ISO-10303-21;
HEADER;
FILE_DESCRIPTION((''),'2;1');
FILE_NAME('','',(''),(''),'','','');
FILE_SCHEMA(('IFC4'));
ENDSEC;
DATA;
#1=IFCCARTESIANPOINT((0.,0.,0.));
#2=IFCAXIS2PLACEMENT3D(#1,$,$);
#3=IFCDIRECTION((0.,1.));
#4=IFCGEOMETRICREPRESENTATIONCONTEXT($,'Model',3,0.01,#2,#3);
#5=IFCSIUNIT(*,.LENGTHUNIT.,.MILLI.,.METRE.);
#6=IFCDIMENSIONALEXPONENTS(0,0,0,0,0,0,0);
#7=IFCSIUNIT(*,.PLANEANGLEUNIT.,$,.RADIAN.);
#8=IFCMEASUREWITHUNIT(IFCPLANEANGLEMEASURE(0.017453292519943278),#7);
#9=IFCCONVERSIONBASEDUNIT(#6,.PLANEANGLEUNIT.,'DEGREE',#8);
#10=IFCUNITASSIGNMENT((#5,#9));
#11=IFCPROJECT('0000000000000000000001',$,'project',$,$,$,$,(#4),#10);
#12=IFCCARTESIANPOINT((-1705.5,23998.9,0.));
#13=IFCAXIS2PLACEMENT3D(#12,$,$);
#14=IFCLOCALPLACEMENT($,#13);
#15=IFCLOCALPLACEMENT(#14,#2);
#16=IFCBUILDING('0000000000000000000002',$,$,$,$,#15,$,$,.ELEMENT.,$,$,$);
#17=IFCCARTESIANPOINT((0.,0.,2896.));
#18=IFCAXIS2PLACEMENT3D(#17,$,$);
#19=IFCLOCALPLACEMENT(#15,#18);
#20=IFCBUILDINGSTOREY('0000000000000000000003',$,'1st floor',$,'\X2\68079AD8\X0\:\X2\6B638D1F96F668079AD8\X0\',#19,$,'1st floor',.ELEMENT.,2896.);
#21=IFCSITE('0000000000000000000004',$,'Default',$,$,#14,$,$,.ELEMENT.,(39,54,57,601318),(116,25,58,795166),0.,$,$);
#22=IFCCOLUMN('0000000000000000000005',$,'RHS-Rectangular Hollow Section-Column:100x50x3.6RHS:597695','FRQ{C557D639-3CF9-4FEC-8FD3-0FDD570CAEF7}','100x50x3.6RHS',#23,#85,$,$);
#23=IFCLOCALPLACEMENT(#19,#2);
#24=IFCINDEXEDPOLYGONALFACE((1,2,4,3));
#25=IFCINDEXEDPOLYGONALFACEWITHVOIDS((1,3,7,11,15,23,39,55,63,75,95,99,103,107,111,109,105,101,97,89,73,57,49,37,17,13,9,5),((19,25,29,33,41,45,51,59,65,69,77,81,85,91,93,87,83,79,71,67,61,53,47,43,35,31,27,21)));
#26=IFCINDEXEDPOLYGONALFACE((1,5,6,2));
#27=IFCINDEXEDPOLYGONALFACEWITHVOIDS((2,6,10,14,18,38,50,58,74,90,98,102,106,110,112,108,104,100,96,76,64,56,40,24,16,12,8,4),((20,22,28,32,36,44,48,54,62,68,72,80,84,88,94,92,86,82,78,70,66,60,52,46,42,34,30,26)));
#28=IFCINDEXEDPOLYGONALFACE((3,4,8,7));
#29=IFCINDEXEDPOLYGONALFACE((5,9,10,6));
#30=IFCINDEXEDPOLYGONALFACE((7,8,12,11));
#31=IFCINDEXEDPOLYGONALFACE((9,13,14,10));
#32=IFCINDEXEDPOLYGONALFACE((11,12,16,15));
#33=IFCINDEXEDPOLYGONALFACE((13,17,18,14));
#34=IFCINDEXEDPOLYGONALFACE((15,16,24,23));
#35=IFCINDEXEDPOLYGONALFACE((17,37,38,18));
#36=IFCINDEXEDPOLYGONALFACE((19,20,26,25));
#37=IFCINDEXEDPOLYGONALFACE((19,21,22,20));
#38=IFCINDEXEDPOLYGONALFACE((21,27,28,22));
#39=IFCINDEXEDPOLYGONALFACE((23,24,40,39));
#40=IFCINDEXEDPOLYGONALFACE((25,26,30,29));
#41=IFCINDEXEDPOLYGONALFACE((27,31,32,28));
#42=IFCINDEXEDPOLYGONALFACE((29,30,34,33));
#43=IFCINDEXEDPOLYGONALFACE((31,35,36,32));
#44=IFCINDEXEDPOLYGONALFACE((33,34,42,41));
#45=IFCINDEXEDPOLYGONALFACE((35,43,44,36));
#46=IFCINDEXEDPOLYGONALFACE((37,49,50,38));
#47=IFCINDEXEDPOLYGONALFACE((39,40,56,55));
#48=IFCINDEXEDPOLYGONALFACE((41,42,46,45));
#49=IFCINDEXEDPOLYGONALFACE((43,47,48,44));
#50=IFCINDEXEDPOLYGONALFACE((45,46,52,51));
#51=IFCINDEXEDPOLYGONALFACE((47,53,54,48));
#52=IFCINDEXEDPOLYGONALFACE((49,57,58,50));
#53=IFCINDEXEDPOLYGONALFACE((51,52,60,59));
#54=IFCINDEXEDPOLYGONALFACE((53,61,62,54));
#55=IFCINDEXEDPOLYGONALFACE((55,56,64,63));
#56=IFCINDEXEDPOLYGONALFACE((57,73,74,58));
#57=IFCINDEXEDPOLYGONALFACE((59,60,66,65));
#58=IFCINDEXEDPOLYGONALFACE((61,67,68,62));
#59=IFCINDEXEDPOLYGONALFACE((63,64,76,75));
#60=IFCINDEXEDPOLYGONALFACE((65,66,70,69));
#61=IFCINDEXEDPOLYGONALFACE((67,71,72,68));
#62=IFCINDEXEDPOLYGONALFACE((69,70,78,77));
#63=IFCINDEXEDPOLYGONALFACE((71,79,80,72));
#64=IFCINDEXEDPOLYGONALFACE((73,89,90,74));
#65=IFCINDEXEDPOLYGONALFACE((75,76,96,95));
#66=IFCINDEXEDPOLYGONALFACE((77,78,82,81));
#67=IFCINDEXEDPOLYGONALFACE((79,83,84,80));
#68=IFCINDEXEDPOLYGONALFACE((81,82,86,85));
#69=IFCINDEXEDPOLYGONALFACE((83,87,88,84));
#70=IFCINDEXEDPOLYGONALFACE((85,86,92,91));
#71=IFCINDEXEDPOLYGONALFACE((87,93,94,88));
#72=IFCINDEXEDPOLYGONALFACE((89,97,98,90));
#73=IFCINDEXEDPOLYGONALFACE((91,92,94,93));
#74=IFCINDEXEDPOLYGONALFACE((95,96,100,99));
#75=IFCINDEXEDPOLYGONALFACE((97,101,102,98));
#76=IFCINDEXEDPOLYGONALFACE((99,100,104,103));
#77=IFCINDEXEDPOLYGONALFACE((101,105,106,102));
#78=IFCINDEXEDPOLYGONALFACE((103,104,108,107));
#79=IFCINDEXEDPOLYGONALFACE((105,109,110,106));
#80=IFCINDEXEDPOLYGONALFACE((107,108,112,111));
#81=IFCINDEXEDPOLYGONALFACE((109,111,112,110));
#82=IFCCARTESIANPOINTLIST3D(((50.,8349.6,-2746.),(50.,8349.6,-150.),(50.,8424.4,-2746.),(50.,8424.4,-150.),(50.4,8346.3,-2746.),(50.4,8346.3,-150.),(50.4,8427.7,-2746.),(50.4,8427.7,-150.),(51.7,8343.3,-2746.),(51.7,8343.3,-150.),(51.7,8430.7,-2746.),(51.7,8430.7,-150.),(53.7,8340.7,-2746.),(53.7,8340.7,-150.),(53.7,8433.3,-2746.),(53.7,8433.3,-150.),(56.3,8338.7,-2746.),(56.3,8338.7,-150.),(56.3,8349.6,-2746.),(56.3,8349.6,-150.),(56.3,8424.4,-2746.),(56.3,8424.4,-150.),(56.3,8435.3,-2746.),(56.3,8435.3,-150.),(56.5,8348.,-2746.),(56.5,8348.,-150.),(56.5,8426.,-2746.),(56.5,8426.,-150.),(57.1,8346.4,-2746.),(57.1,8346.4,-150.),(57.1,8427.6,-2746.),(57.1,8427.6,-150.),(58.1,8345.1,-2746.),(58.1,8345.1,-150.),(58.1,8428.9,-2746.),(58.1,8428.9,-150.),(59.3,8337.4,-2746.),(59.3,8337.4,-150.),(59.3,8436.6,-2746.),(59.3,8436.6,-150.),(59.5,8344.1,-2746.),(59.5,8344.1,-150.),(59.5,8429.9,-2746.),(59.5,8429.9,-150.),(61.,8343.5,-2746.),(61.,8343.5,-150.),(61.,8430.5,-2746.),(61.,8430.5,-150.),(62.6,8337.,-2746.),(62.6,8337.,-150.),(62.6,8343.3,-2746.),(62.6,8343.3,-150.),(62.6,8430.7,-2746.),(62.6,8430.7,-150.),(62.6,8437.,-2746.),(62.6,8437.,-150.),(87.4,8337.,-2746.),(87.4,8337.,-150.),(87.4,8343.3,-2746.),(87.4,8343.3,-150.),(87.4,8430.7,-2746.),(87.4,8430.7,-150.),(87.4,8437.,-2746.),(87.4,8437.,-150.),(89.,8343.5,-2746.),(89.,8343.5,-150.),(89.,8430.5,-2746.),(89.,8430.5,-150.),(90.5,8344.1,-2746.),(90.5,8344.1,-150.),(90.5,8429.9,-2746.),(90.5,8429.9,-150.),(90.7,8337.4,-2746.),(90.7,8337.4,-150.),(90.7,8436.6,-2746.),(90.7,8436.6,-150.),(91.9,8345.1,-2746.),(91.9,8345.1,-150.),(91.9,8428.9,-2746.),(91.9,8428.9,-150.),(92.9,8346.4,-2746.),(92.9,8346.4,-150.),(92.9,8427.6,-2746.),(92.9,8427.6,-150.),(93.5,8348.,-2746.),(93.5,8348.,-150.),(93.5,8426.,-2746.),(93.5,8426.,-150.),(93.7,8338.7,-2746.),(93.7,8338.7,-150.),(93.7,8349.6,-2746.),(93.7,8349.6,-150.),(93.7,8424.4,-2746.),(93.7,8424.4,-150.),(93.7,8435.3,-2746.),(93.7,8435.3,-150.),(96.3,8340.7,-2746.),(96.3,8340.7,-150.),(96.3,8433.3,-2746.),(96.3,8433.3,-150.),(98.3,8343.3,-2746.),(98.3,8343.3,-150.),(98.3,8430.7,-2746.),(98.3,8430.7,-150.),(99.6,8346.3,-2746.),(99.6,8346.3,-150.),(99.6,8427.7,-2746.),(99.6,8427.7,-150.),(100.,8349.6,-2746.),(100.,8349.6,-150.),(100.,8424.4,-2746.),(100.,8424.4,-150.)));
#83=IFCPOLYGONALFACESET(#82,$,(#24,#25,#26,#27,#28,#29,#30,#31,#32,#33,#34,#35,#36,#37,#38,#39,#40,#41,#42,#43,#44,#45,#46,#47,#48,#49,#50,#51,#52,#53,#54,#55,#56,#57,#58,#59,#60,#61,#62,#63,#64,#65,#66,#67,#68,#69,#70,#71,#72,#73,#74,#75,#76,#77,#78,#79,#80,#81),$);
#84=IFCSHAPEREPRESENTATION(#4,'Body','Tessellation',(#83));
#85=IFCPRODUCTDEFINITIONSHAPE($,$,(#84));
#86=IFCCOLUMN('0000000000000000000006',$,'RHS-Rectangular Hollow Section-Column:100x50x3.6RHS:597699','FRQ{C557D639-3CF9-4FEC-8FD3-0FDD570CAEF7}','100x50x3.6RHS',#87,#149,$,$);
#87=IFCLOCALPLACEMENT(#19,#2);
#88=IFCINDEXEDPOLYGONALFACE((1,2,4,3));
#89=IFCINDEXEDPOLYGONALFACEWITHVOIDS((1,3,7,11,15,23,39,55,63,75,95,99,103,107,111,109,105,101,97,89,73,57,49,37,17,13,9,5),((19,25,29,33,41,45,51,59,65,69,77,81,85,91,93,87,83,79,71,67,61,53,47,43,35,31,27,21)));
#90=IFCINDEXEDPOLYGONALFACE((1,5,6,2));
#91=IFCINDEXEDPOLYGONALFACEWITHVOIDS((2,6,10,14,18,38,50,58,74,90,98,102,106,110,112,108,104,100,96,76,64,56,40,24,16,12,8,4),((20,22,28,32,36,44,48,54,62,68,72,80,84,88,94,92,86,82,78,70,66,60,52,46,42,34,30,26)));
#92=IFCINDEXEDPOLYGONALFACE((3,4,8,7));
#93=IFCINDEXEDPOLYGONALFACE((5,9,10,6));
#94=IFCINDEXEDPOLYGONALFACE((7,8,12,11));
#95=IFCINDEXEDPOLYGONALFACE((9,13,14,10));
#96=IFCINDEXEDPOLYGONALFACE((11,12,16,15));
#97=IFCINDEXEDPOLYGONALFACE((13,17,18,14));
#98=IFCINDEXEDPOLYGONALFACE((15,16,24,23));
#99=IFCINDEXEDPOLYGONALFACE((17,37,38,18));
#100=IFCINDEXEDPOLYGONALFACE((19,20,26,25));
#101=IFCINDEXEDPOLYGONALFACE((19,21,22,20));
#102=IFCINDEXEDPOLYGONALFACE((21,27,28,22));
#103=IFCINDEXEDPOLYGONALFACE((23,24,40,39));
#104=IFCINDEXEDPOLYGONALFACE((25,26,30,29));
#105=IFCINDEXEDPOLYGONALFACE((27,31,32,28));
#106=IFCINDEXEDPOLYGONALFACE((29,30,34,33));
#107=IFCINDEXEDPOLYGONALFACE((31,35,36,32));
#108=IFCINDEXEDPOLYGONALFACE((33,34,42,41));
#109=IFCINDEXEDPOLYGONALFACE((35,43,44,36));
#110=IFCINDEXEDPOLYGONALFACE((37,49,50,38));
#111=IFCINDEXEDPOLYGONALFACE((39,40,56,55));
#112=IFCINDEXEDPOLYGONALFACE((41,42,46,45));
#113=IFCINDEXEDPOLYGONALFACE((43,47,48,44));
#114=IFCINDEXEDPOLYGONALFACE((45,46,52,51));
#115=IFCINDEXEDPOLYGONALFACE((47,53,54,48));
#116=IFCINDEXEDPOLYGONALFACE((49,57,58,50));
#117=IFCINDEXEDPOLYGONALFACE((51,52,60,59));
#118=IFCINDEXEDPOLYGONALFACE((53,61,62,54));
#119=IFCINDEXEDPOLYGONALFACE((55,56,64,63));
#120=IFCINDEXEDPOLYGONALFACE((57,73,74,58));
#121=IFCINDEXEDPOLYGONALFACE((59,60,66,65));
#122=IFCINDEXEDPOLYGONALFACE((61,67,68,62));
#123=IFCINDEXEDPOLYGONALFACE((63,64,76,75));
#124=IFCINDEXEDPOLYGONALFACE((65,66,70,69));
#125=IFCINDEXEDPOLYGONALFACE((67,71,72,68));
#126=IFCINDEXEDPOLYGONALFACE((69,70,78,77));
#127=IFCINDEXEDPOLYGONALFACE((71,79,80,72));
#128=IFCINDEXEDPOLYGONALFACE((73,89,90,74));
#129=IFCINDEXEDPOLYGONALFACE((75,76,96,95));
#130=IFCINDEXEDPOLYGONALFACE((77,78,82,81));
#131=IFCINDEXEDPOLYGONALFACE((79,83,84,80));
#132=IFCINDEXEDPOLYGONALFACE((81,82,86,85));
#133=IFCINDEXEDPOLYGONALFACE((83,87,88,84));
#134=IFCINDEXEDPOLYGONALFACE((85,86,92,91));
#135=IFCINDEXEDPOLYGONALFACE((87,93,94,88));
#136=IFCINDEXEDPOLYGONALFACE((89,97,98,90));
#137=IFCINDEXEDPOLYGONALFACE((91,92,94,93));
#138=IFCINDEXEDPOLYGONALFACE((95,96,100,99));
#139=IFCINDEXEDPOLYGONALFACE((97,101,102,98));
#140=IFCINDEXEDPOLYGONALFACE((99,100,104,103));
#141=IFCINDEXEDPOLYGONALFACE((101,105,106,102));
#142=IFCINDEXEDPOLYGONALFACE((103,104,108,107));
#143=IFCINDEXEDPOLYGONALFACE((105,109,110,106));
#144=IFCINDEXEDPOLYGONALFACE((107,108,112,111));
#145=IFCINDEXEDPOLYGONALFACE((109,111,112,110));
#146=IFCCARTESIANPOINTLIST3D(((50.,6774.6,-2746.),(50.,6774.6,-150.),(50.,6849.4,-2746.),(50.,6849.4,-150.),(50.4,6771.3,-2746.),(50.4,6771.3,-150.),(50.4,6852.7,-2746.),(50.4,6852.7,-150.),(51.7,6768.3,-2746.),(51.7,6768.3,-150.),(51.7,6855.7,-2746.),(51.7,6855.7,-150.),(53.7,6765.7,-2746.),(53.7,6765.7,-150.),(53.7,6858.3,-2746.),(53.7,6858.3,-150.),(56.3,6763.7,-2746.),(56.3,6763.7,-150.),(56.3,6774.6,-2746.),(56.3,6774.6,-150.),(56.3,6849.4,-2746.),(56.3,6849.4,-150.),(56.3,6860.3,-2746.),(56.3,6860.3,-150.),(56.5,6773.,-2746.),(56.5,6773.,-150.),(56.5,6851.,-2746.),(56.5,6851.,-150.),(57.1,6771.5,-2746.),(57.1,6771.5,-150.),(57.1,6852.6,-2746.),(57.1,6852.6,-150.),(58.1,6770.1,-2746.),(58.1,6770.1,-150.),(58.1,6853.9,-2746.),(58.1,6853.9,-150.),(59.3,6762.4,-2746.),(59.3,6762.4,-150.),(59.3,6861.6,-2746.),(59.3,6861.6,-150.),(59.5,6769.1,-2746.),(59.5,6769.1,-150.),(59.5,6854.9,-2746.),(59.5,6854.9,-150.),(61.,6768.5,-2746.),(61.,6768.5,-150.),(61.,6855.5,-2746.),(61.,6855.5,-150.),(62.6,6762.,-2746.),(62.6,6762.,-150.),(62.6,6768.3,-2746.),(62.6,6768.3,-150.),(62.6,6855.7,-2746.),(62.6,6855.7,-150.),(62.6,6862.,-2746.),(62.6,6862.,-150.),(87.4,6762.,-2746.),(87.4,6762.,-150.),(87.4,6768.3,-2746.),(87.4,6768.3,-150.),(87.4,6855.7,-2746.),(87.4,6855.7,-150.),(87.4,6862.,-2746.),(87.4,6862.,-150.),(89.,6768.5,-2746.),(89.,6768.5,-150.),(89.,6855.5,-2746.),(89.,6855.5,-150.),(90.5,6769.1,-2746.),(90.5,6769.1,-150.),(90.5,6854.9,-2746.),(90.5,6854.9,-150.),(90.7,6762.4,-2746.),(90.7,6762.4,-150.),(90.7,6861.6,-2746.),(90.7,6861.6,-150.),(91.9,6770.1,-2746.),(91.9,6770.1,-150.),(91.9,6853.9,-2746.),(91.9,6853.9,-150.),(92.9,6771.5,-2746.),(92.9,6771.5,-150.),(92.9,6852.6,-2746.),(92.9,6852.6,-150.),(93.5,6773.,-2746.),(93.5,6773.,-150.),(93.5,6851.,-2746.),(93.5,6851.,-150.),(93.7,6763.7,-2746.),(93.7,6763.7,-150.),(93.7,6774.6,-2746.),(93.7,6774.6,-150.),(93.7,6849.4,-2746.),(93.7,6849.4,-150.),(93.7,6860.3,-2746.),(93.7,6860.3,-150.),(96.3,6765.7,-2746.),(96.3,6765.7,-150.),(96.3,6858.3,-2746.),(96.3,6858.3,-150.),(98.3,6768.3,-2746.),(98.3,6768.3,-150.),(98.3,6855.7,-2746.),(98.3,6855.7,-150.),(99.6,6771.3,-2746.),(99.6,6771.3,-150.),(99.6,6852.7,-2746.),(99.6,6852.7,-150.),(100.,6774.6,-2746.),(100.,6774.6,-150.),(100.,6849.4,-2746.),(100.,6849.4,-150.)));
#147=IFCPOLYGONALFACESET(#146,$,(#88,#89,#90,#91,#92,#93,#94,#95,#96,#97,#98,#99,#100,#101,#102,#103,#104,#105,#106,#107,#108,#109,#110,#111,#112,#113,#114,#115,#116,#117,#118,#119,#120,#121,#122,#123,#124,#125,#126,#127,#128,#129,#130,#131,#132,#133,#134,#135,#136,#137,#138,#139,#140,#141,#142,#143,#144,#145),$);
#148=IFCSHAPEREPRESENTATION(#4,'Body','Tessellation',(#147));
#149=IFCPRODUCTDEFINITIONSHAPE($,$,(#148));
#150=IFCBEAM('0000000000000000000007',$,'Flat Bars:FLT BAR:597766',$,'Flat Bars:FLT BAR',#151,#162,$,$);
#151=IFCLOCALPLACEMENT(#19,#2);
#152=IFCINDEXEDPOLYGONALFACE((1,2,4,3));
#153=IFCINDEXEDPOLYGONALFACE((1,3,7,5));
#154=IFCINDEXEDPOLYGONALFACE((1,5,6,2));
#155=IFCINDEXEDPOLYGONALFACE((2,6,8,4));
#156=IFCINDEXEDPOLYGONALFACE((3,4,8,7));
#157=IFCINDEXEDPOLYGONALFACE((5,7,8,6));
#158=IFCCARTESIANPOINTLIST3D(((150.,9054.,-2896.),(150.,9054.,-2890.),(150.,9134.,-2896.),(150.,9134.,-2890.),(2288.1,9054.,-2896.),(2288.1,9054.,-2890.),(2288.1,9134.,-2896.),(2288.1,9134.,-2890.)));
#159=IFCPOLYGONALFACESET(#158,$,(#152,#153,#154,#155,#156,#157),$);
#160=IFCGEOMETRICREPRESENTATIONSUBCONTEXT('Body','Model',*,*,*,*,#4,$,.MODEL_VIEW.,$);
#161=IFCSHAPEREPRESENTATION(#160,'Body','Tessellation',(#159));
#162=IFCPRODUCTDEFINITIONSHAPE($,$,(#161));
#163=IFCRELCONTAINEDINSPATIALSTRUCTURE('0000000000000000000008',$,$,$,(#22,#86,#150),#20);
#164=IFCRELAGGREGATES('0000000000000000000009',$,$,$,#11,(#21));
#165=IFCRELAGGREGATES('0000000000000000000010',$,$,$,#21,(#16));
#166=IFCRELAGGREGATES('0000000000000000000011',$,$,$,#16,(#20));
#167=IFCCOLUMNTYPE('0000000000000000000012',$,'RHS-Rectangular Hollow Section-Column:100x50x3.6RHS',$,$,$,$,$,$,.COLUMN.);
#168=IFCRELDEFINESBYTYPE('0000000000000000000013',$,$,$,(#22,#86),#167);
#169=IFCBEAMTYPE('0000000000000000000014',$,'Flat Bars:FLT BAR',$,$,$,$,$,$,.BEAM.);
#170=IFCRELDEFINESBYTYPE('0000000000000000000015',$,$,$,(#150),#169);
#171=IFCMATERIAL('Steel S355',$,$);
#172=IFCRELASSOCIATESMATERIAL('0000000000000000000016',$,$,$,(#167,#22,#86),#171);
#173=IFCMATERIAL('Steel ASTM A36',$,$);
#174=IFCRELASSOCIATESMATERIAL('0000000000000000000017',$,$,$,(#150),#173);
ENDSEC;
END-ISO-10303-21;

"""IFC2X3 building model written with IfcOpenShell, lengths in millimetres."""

from ifc_helpers import new_model, entity, si_unit, converted_unit, point, direction, frame, frame_2d, origin, origin_2d, origin_2d_with_axis, place, context, subcontext, project, spatial, circle_curve, line_curve, trimmed, segment, composite_curve, rectangle, hollow_rectangle, outline, extrude, clip, halfspace, material, type_object, element, save


model = new_model("IFC2X3")

# Units and contexts
model_context = context("Model", 3, precision=0.01, world=origin(), true_north=direction((0.0, 1.0)))
body_context = subcontext(model_context, "Body", "Model", "MODEL_VIEW")
ifc_project = project(units=[si_unit("LENGTHUNIT", "METRE", prefix="MILLI"), converted_unit("PLANEANGLEUNIT", "DEGREE", entity("IfcPlaneAngleMeasure", 0.017453292519943278), si_unit("PLANEANGLEUNIT", "RADIAN"), dimensions=[0, 0, 0, 0, 0, 0, 0])], contexts=[model_context])

# Site, building, storey
site_placement = place(None, frame((-1705.5, 23998.9, 0.0)))
site = spatial("IfcSite", under=ifc_project, at=site_placement, Name="Default", CompositionType="ELEMENT", RefLatitude=(39, 54, 57, 601318), RefLongitude=(116, 25, 58, 795166), RefElevation=0.0)
building_placement = place(site_placement, origin())
building = spatial("IfcBuilding", under=site, at=building_placement, CompositionType="ELEMENT")
storey_placement = place(building_placement, frame((0.0, 0.0, 2896.0)))
storey = spatial("IfcBuildingStorey", under=building, at=storey_placement, Name="1st floor", ObjectType="标高:正负零标高", LongName="1st floor", CompositionType="ELEMENT", Elevation=2896.0)

# Shared definitions
ifc_material_1 = material(Name="Steel S355")

# Columns, openings
column_type_1 = type_object("IfcColumnType", Name="RHS-Rectangular Hollow Section-Column:100x50x3.6RHS", PredefinedType="COLUMN", material=ifc_material_1)
column_1_placement = place(storey_placement, frame((75.0, 8387.0, -19.1)))
column_1 = element("IfcColumn", 1, at=column_1_placement, inside=storey, type_object=column_type_1, material=ifc_material_1, Name="RHS-Rectangular Hollow Section-Column:100x50x3.6RHS:597695", Description="FRQ{C557D639-3CF9-4FEC-8FD3-0FDD570CAEF7}", ObjectType="100x50x3.6RHS", context=model_context, shape_type="Clipping", body=[
    clip(clip(extrude(hollow_rectangle(XDim=50.0, YDim=100.0, WallThickness=6.3, InnerFilletRadius=6.3, OuterFilletRadius=12.6, at=origin_2d()), origin(), (0.0, 0.0, -1.0), 2782.8), halfspace(frame((-75.0, -8387.0, -2726.9), z_axis=(0.0, 0.0, 1.0), x_axis=(1.0, 0.0, 0.0)), True)), halfspace(frame((-75.0, -8387.0, -55.9), z_axis=(0.0, 0.0, -1.0), x_axis=(-1.0, 0.0, 0.0)), True)),
])
opening_1_placement = place(column_1_placement, frame((0.0, -150.1, -130.9), z_axis=(0.0, 1.0, 0.0), x_axis=(-1.0, 0.0, 0.0)))
element("IfcOpeningElement", 2, at=opening_1_placement, cuts=column_1, ObjectType="Opening", context=model_context, shape_type="SweptSolid", body=[
    extrude(outline(composite_curve([segment(trimmed(circle_curve(frame_2d((43.0, 32.0), x_axis=(1.0, 0.0)), 32.0), [point((43.0, 0.0))], [point((75.0, 32.0))], True, "CARTESIAN"), True, "CONTINUOUS"), segment(trimmed(line_curve((75.0, 32.0), (0.0, 1.0), 86.0), [point((75.0, 32.0))], [point((75.0, 118.0))], True, "CARTESIAN"), True, "CONTINUOUS"), segment(trimmed(circle_curve(frame_2d((43.0, 118.0), x_axis=(1.0, 0.0)), 32.0), [point((75.0, 118.0))], [point((43.0, 150.0))], True, "CARTESIAN"), True, "CONTINUOUS"), segment(trimmed(line_curve((43.0, 150.0), (-1.0, 0.0), 86.0), [point((43.0, 150.0))], [point((-43.0, 150.0))], True, "CARTESIAN"), True, "CONTINUOUS"), segment(trimmed(circle_curve(frame_2d((-43.0, 118.0), x_axis=(1.0, 0.0)), 32.0), [point((-43.0, 150.0))], [point((-75.0, 118.0))], True, "CARTESIAN"), True, "CONTINUOUS"), segment(trimmed(line_curve((-75.0, 118.0), (0.0, -1.0), 86.0), [point((-75.0, 118.0))], [point((-75.0, 32.0))], True, "CARTESIAN"), True, "CONTINUOUS"), segment(trimmed(circle_curve(frame_2d((-43.0, 32.0), x_axis=(1.0, 0.0)), 32.0), [point((-75.0, 32.0))], [point((-43.0, 0.0))], True, "CARTESIAN"), True, "CONTINUOUS"), segment(trimmed(line_curve((-43.0, 0.0), (1.0, 0.0), 86.0), [point((-43.0, 0.0))], [point((43.0, 0.0))], True, "CARTESIAN"), True, "CONTINUOUS")], self_intersect="UNKNOWN")), origin(), (0.0, 0.0, 1.0), 300.2),
])
column_2_placement = place(storey_placement, frame((75.0, 6812.0, -19.1)))
column_2 = element("IfcColumn", 3, at=column_2_placement, inside=storey, type_object=column_type_1, material=ifc_material_1, Name="RHS-Rectangular Hollow Section-Column:100x50x3.6RHS:597699", Description="FRQ{C557D639-3CF9-4FEC-8FD3-0FDD570CAEF7}", ObjectType="100x50x3.6RHS", context=model_context, shape_type="Clipping", body=[
    clip(clip(extrude(hollow_rectangle(XDim=50.0, YDim=100.0, WallThickness=6.3, InnerFilletRadius=6.3, OuterFilletRadius=12.6, at=origin_2d()), origin(), (0.0, 0.0, -1.0), 2782.8), halfspace(frame((-75.0, -6812.0, -2726.9), z_axis=(0.0, 0.0, 1.0), x_axis=(1.0, 0.0, 0.0)), True)), halfspace(frame((-75.0, -6812.0, -55.9), z_axis=(0.0, 0.0, -1.0), x_axis=(-1.0, 0.0, 0.0)), True)),
])
opening_2_placement = place(column_2_placement, frame((0.0, -150.1, -130.9), z_axis=(0.0, 1.0, 0.0), x_axis=(-1.0, 0.0, 0.0)))
element("IfcOpeningElement", 4, at=opening_2_placement, cuts=column_2, ObjectType="Opening", context=model_context, shape_type="SweptSolid", body=[
    extrude(outline(composite_curve([segment(trimmed(circle_curve(frame_2d((43.0, 32.0), x_axis=(1.0, 0.0)), 32.0), [point((43.0, 0.0))], [point((75.0, 32.0))], True, "CARTESIAN"), True, "CONTINUOUS"), segment(trimmed(line_curve((75.0, 32.0), (0.0, 1.0), 86.0), [point((75.0, 32.0))], [point((75.0, 118.0))], True, "CARTESIAN"), True, "CONTINUOUS"), segment(trimmed(circle_curve(frame_2d((43.0, 118.0), x_axis=(1.0, 0.0)), 32.0), [point((75.0, 118.0))], [point((43.0, 150.0))], True, "CARTESIAN"), True, "CONTINUOUS"), segment(trimmed(line_curve((43.0, 150.0), (-1.0, 0.0), 86.0), [point((43.0, 150.0))], [point((-43.0, 150.0))], True, "CARTESIAN"), True, "CONTINUOUS"), segment(trimmed(circle_curve(frame_2d((-43.0, 118.0), x_axis=(1.0, 0.0)), 32.0), [point((-43.0, 150.0))], [point((-75.0, 118.0))], True, "CARTESIAN"), True, "CONTINUOUS"), segment(trimmed(line_curve((-75.0, 118.0), (0.0, -1.0), 86.0), [point((-75.0, 118.0))], [point((-75.0, 32.0))], True, "CARTESIAN"), True, "CONTINUOUS"), segment(trimmed(circle_curve(frame_2d((-43.0, 32.0), x_axis=(1.0, 0.0)), 32.0), [point((-75.0, 32.0))], [point((-43.0, 0.0))], True, "CARTESIAN"), True, "CONTINUOUS"), segment(trimmed(line_curve((-43.0, 0.0), (1.0, 0.0), 86.0), [point((-43.0, 0.0))], [point((43.0, 0.0))], True, "CARTESIAN"), True, "CONTINUOUS")], self_intersect="UNKNOWN")), origin(), (0.0, 0.0, 1.0), 300.2),
])

# Beam
ifc_material_2 = material(Name="Steel ASTM A36")
beam_type_1 = type_object("IfcBeamType", Name="Flat Bars:FLT BAR", PredefinedType="BEAM")
for number, where, name in (
    (5, (150.0, 9094.0, -2890.0), "Flat Bars:FLT BAR:597766"),
):
    element("IfcBeam", number, at=place(storey_placement, frame(where)), inside=storey, type_object=beam_type_1, material=ifc_material_2, Name=name, ObjectType="Flat Bars:FLT BAR", context=body_context, shape_type="SweptSolid", body=[
        extrude(rectangle(XDim=6.0, YDim=80.0, at=origin_2d_with_axis()), frame((0.0, 0.0, -3.0), z_axis=(1.0, 0.0, 0.0), x_axis=(0.0, 0.0, -1.0)), (0.0, 0.0, 1.0), 2138.1),
    ])

save(model, "model.ifc")
